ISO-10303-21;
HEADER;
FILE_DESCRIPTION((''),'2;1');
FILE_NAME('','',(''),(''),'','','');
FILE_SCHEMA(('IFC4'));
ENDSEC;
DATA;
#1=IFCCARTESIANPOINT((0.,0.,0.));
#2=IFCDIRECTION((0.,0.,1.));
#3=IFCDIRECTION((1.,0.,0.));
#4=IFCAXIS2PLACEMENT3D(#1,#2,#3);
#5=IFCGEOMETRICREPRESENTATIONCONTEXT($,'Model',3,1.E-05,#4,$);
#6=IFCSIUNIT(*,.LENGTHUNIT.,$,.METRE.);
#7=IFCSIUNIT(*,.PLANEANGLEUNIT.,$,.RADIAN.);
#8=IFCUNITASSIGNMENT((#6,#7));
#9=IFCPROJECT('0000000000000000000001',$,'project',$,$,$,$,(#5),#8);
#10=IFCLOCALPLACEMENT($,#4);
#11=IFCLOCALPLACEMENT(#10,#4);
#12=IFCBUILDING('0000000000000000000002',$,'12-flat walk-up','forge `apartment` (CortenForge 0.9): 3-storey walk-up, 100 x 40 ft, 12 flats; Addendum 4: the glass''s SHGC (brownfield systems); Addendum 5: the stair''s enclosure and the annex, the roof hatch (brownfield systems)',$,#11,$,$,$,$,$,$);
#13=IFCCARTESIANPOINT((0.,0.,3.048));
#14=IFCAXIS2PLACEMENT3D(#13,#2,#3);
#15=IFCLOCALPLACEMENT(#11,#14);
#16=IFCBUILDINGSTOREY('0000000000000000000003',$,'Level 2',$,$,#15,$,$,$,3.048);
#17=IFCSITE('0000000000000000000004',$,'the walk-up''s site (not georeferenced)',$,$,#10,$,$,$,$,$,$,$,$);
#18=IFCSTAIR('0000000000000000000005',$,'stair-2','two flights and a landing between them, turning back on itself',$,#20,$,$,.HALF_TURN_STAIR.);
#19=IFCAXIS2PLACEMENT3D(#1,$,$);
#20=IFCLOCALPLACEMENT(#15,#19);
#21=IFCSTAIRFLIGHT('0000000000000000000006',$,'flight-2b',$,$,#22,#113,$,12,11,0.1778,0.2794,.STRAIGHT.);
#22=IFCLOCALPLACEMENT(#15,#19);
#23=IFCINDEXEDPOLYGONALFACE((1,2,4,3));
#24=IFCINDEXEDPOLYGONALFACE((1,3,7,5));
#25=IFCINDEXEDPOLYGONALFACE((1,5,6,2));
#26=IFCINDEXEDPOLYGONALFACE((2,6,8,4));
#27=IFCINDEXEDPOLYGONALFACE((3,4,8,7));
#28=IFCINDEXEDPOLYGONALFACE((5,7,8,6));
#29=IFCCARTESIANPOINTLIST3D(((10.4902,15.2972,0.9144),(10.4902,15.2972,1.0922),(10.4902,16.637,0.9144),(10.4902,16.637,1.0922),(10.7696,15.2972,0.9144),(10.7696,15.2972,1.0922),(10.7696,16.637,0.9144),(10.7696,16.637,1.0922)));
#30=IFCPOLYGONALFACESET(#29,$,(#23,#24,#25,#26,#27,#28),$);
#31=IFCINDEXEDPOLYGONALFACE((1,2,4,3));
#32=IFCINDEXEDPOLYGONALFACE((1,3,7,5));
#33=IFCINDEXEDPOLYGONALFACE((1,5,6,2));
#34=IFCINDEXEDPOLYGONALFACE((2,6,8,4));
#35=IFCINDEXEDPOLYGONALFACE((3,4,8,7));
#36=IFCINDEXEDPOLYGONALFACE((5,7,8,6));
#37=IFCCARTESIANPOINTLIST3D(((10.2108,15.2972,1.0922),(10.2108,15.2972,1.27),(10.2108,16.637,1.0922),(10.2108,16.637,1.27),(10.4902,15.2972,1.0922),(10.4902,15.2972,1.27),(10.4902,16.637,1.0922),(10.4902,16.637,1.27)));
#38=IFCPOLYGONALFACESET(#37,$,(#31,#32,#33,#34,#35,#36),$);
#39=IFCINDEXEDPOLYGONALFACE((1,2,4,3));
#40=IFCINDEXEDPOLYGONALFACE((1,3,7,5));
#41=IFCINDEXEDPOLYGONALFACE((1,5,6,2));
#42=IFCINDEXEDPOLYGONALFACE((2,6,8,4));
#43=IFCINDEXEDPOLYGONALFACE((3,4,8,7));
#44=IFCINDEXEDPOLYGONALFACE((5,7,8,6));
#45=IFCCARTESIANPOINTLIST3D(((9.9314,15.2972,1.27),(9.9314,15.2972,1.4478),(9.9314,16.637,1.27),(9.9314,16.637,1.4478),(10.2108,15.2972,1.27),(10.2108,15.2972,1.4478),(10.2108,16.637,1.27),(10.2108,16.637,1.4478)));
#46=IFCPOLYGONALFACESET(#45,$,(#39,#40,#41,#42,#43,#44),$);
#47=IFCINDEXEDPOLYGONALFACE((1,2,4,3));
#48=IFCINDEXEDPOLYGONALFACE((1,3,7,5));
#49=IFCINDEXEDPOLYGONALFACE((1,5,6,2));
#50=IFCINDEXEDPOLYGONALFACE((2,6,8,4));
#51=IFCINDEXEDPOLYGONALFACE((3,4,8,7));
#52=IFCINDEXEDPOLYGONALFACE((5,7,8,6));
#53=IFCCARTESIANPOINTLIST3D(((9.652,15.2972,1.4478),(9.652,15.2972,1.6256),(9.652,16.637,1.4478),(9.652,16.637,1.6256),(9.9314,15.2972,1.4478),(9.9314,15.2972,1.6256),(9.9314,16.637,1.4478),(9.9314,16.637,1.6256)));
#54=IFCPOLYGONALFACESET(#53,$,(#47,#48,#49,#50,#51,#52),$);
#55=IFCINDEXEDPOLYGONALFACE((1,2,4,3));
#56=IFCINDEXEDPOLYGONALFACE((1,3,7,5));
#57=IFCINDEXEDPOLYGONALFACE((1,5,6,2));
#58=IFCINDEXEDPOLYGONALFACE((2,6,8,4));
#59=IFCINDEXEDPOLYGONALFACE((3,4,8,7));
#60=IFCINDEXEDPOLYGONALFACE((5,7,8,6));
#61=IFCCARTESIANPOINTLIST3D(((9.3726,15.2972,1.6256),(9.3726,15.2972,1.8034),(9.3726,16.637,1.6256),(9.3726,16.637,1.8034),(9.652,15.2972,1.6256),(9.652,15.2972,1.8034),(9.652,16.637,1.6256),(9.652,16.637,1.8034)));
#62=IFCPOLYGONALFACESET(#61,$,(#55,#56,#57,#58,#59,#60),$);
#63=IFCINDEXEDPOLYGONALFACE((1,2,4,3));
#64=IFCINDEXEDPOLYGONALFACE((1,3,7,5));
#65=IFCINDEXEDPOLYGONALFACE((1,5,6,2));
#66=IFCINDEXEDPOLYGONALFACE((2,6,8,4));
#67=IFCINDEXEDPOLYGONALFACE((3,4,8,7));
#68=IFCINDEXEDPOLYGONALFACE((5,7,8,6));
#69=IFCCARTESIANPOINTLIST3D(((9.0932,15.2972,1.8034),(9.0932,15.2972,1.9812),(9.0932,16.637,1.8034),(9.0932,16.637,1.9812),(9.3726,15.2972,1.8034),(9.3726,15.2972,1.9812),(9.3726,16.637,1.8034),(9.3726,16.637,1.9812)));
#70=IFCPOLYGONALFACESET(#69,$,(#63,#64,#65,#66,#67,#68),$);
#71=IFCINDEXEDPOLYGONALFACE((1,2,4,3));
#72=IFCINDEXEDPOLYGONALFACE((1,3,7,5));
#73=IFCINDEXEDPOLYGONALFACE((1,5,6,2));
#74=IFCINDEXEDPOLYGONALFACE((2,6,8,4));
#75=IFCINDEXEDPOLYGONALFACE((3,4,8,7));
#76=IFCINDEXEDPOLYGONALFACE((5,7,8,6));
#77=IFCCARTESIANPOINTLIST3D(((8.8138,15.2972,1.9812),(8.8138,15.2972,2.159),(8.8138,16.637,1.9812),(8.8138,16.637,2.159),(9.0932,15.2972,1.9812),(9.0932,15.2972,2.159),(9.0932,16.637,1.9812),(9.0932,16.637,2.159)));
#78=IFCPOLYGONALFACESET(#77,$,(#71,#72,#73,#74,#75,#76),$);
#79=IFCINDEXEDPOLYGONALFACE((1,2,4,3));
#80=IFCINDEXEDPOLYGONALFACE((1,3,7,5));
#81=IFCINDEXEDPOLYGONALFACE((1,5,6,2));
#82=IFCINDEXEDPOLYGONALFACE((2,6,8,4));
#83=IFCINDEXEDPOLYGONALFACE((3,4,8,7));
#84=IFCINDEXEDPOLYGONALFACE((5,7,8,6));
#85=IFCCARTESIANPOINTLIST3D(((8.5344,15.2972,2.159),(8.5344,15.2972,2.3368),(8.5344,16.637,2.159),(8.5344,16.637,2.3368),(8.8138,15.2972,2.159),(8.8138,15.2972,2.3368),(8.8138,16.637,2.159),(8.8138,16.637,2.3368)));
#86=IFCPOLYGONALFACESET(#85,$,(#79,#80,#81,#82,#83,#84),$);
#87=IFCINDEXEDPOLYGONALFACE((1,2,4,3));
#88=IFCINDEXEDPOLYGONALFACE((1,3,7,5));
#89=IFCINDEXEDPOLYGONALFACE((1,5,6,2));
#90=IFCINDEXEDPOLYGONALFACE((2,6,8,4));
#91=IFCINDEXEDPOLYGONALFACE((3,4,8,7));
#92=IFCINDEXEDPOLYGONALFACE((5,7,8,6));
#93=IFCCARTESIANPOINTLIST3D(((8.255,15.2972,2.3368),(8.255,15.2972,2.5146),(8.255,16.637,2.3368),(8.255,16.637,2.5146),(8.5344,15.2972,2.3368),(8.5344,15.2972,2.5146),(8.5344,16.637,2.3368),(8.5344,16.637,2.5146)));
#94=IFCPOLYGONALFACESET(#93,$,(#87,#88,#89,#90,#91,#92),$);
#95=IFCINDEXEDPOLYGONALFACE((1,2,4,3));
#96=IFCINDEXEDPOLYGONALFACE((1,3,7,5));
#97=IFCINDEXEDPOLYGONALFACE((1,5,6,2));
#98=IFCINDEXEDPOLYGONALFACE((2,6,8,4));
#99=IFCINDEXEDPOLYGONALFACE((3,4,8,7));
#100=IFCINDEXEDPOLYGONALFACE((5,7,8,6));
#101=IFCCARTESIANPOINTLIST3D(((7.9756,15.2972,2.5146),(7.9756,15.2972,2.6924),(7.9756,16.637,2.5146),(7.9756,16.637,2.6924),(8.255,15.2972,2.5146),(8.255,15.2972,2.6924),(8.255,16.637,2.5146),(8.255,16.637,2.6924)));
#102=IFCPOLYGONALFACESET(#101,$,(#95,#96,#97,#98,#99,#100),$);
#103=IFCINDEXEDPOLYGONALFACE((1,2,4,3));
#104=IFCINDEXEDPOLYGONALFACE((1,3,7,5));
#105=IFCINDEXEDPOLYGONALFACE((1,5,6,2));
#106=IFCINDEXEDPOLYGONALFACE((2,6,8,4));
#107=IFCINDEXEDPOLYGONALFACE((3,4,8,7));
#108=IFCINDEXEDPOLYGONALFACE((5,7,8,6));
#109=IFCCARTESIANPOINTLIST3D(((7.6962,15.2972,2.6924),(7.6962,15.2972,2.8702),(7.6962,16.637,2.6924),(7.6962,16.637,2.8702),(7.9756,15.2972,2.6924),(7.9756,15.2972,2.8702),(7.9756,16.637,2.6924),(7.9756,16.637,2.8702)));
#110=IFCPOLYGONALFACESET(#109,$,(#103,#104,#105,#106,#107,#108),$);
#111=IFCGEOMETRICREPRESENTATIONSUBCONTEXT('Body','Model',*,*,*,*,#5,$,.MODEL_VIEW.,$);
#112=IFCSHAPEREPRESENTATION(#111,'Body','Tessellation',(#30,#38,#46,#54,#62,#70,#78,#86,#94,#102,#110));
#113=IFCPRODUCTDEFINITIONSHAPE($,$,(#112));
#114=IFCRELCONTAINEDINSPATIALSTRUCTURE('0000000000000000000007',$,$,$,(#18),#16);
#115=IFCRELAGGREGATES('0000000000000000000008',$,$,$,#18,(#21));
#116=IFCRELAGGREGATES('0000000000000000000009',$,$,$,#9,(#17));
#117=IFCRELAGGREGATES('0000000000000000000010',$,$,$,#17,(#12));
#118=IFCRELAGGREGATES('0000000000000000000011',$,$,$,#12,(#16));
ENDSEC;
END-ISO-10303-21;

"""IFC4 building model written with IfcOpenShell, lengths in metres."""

from ifc_helpers import new_model, si_unit, frame, frame_2d, origin_with_axes, place, context, subcontext, project, spatial, rectangle, extrude, element, aggregate, save


model = new_model("IFC4")

# Units and contexts
model_context = context("Model", 3, precision=1e-05, world=origin_with_axes())
body_context = subcontext(model_context, "Body", "Model", "MODEL_VIEW")
ifc_project = project(units=[si_unit("LENGTHUNIT", "METRE"), si_unit("PLANEANGLEUNIT", "RADIAN")], contexts=[model_context])

# Site, building, storey
site_placement = place(None, origin_with_axes())
site = spatial("IfcSite", under=ifc_project, at=site_placement, Name="the walk-up's site (not georeferenced)")
building_placement = place(site_placement, origin_with_axes())
building = spatial("IfcBuilding", under=site, at=building_placement, Name="12-flat walk-up", Description="forge `apartment` (CortenForge 0.9): 3-storey walk-up, 100 x 40 ft, 12 flats; Addendum 4: the glass's SHGC (brownfield systems); Addendum 5: the stair's enclosure and the annex, the roof hatch (brownfield systems)")
storey_placement = place(building_placement, frame((0.0, 0.0, 3.048), z_axis=(0.0, 0.0, 1.0), x_axis=(1.0, 0.0, 0.0)))
storey = spatial("IfcBuildingStorey", under=building, at=storey_placement, Name="Level 2", Elevation=3.048)

# Stair, stair flight
stair_placement = place(storey_placement, frame((0.0, 0.0, -3.048), z_axis=(0.0, 0.0, 1.0), x_axis=(1.0, 0.0, 0.0)))
stair = element("IfcStair", 1, at=stair_placement, inside=storey, Name="stair-2", Description="two flights and a landing between them, turning back on itself", PredefinedType="HALF_TURN_STAIR")
stair_flight_placement = place(stair_placement, frame((7.6962, 15.2972, 3.9624), z_axis=(0.0, 0.0, 1.0), x_axis=(1.0, 0.0, 0.0)))
stair_flight = element("IfcStairFlight", 2, at=stair_flight_placement, Name="flight-2b", NumberOfRisers=12, NumberOfTreads=11, PredefinedType="STRAIGHT", RiserHeight=0.1778, TreadLength=0.2794, context=body_context, shape_type="SweptSolid", body=[
    extrude(rectangle(XDim=0.2794, YDim=1.3399, at=frame_2d((0.1397, 0.6699))), frame((2.794, 0.0, 0.0)), (0.0, 0.0, 1.0), 0.1778),
    extrude(rectangle(XDim=0.2794, YDim=1.3399, at=frame_2d((0.1397, 0.6699))), frame((2.5146, 0.0, 0.1778)), (0.0, 0.0, 1.0), 0.1778),
    extrude(rectangle(XDim=0.2794, YDim=1.3399, at=frame_2d((0.1397, 0.6699))), frame((2.2352, 0.0, 0.3556)), (0.0, 0.0, 1.0), 0.1778),
    extrude(rectangle(XDim=0.2794, YDim=1.3399, at=frame_2d((0.1397, 0.6699))), frame((1.9558, 0.0, 0.5334)), (0.0, 0.0, 1.0), 0.1778),
    extrude(rectangle(XDim=0.2794, YDim=1.3399, at=frame_2d((0.1397, 0.6699))), frame((1.6764, 0.0, 0.7112)), (0.0, 0.0, 1.0), 0.1778),
    extrude(rectangle(XDim=0.2794, YDim=1.3399, at=frame_2d((0.1397, 0.6699))), frame((1.397, 0.0, 0.889)), (0.0, 0.0, 1.0), 0.1778),
    extrude(rectangle(XDim=0.2794, YDim=1.3399, at=frame_2d((0.1397, 0.6699))), frame((1.1176, 0.0, 1.0668)), (0.0, 0.0, 1.0), 0.1778),
    extrude(rectangle(XDim=0.2794, YDim=1.3399, at=frame_2d((0.1397, 0.6699))), frame((0.8382, 0.0, 1.2446)), (0.0, 0.0, 1.0), 0.1778),
    extrude(rectangle(XDim=0.2794, YDim=1.3399, at=frame_2d((0.1397, 0.6699))), frame((0.5588, 0.0, 1.4224)), (0.0, 0.0, 1.0), 0.1778),
    extrude(rectangle(XDim=0.2794, YDim=1.3399, at=frame_2d((0.1397, 0.6699))), frame((0.2794, 0.0, 1.6002)), (0.0, 0.0, 1.0), 0.1778),
    extrude(rectangle(XDim=0.2794, YDim=1.3399, at=frame_2d((0.1397, 0.6699))), frame((0.0, 0.0, 1.778)), (0.0, 0.0, 1.0), 0.1778),
])
aggregate(stair, [stair_flight])

save(model, "model.ifc")
